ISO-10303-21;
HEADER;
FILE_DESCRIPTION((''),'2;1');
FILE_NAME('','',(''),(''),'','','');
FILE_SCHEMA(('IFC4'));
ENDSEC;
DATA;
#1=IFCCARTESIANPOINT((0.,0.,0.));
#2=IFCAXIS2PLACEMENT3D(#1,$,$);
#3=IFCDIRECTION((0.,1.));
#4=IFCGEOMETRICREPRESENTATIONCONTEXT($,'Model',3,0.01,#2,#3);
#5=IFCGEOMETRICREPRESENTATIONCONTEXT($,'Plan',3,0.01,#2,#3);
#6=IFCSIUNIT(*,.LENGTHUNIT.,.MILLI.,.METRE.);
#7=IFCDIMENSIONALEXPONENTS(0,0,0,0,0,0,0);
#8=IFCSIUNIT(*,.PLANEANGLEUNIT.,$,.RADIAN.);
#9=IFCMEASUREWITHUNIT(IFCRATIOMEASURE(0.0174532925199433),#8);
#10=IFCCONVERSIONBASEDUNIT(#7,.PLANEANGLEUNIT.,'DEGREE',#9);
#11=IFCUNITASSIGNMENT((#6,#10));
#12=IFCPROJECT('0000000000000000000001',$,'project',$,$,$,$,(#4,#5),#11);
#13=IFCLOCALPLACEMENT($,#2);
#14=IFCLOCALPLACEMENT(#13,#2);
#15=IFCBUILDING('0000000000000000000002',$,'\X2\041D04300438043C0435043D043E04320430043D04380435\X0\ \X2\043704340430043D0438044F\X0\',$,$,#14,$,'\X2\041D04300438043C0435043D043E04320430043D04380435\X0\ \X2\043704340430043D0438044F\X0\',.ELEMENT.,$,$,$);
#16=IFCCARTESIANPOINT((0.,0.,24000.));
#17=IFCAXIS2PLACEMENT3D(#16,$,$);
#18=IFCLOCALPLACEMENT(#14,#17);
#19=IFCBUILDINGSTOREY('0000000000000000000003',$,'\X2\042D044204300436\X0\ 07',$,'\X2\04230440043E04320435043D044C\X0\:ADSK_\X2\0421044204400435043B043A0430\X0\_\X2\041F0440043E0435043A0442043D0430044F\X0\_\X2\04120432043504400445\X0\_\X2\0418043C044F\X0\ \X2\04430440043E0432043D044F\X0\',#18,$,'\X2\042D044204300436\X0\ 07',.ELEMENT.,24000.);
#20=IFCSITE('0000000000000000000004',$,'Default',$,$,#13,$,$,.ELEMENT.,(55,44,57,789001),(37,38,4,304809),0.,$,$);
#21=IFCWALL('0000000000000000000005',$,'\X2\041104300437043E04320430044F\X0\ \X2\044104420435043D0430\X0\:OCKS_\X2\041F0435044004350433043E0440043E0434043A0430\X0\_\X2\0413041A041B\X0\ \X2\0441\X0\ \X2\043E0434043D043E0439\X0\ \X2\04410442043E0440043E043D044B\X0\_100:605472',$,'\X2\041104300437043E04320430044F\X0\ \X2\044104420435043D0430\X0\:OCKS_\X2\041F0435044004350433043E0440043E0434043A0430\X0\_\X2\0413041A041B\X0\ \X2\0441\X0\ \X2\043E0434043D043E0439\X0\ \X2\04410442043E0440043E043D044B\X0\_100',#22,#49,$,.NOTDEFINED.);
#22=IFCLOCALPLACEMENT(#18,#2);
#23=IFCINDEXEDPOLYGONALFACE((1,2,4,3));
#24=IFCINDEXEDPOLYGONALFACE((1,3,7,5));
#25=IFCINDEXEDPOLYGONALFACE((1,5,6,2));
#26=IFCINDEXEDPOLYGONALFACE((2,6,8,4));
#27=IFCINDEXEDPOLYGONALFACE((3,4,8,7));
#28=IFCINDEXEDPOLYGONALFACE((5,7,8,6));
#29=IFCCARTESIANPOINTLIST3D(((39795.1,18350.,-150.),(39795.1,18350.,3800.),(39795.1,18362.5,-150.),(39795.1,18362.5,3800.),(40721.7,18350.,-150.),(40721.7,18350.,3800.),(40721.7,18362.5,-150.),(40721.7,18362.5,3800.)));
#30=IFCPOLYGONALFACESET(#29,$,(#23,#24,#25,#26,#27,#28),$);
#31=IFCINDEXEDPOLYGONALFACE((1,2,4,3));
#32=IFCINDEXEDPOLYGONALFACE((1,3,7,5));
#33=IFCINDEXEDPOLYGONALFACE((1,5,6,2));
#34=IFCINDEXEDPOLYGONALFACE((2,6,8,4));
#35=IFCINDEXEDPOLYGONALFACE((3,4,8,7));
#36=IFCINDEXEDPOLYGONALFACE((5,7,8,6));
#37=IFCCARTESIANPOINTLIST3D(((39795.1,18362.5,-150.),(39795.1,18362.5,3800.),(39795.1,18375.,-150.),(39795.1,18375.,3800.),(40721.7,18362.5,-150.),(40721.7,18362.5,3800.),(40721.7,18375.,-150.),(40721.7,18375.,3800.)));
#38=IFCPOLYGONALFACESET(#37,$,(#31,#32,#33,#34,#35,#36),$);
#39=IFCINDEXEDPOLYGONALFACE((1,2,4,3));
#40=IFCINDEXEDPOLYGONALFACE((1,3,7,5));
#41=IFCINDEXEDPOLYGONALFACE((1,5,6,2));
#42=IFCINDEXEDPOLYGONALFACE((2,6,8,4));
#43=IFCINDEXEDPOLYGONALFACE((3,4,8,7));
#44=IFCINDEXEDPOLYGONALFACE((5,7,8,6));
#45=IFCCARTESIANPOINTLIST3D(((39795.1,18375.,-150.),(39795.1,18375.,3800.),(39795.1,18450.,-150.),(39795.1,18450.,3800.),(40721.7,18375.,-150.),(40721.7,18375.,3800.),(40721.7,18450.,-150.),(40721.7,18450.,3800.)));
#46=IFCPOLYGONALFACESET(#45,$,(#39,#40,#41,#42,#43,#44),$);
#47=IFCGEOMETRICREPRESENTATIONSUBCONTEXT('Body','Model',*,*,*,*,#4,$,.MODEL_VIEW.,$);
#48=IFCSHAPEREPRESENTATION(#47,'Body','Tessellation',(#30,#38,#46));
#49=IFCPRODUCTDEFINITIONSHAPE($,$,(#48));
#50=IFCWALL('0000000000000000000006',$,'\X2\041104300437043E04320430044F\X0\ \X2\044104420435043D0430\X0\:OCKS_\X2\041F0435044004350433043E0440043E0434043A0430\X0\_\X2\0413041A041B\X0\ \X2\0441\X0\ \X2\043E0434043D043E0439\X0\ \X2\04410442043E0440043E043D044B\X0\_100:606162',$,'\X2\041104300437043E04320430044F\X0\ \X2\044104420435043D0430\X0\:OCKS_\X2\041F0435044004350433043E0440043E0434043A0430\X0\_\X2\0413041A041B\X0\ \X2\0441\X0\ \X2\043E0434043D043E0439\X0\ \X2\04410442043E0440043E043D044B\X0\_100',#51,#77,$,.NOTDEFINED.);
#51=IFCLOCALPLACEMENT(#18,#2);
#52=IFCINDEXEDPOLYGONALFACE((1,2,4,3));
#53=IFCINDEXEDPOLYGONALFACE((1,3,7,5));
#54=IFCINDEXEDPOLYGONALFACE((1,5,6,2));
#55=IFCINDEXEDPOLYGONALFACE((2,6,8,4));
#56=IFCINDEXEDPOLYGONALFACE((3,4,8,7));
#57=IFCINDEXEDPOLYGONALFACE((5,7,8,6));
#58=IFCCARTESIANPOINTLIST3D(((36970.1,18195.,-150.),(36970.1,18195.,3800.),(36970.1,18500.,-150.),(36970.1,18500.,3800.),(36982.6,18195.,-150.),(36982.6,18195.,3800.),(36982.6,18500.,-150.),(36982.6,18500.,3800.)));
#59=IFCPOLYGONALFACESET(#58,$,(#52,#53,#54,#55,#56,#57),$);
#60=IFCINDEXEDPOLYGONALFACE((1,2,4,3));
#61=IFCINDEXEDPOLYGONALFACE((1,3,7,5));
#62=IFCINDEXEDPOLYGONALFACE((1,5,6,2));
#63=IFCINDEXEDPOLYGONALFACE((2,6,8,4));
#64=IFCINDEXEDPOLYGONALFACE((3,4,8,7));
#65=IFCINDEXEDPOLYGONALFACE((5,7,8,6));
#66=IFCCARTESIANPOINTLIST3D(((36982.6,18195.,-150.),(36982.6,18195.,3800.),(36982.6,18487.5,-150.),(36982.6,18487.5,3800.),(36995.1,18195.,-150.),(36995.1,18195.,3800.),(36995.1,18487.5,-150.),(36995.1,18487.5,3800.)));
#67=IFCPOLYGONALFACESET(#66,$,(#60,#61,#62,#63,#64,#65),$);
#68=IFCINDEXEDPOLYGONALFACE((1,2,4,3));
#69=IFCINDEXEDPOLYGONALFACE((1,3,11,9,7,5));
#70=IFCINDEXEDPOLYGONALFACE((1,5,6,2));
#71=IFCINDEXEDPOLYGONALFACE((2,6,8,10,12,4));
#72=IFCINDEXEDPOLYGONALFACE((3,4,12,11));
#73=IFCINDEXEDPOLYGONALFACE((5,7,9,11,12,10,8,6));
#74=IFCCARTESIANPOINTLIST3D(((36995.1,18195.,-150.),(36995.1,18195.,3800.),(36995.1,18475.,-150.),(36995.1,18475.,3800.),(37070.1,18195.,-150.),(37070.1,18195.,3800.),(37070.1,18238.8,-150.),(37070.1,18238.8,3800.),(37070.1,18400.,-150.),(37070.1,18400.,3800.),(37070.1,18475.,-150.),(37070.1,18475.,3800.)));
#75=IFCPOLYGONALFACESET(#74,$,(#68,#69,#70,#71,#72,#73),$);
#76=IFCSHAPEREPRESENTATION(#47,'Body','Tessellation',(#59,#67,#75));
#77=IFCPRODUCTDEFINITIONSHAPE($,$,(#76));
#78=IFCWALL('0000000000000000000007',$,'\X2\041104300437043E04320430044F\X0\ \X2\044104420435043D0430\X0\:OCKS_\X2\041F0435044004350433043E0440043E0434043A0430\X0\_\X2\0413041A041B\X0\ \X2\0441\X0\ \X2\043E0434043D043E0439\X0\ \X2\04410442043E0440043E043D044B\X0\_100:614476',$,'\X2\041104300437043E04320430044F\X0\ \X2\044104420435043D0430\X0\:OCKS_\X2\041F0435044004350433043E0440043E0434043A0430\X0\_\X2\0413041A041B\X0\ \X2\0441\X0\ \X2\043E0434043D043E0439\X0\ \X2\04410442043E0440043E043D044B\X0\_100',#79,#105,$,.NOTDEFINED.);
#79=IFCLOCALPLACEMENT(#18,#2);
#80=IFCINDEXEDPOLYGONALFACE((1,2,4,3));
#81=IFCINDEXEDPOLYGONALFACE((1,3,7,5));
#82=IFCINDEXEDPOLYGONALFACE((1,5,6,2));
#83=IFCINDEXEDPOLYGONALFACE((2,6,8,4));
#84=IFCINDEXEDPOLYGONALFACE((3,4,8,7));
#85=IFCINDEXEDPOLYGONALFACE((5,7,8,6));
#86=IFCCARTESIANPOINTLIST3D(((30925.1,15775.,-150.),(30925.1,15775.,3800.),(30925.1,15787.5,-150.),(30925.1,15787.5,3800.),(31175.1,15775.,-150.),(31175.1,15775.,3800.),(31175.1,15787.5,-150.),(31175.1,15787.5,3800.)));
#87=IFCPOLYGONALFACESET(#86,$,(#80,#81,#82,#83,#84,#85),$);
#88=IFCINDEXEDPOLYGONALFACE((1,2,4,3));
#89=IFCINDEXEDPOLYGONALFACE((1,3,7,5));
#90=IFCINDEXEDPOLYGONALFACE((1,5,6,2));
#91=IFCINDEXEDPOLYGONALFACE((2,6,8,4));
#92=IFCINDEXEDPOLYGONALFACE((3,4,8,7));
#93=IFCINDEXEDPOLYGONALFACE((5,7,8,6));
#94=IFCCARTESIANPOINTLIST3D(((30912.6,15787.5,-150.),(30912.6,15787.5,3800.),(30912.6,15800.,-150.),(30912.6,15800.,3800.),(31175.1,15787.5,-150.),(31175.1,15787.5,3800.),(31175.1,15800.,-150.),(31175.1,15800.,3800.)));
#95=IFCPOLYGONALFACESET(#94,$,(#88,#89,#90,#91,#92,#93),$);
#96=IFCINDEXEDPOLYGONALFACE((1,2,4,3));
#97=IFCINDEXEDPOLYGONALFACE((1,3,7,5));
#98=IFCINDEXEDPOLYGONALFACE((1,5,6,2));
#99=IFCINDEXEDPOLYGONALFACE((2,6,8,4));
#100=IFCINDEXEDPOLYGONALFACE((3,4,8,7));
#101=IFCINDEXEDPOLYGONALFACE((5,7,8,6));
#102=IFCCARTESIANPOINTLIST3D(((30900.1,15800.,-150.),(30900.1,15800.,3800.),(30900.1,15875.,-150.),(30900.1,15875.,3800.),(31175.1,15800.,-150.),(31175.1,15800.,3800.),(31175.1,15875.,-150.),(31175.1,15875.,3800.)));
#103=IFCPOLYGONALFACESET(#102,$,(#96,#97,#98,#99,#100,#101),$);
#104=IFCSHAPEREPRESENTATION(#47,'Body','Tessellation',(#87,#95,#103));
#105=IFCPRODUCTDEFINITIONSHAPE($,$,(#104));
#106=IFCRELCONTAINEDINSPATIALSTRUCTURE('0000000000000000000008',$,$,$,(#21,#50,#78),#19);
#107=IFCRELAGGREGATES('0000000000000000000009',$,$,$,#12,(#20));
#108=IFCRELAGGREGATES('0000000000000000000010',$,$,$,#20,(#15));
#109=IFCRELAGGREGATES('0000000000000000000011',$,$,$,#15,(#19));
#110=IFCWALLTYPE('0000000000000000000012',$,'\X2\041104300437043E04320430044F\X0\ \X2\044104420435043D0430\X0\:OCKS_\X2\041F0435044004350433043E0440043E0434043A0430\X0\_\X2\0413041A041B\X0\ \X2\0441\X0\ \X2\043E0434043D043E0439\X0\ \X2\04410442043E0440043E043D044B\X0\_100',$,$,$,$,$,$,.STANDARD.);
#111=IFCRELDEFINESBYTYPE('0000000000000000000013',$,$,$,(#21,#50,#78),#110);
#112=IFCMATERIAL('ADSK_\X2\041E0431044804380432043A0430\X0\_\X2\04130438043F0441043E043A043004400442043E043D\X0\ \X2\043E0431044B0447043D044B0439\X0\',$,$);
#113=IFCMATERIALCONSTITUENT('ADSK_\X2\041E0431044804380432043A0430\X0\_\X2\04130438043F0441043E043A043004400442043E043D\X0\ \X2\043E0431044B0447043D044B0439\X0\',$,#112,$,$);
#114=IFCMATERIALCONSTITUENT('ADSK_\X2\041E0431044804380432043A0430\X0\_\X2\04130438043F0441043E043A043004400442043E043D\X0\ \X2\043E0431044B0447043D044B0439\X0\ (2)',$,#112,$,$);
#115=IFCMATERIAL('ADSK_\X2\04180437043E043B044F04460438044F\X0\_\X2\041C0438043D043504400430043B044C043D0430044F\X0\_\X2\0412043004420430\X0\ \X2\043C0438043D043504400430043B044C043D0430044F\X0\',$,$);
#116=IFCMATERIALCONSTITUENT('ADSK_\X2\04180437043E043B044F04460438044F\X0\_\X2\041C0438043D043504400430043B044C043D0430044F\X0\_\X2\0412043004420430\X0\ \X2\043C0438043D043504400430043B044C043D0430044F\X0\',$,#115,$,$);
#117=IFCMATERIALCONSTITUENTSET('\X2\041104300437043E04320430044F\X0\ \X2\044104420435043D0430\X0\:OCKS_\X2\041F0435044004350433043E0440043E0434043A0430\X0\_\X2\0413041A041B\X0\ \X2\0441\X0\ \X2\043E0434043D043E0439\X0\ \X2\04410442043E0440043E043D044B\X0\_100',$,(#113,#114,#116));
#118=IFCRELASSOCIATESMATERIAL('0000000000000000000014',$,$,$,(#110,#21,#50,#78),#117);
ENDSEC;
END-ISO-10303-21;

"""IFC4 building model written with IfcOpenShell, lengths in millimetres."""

from ifc_helpers import new_model, entity, si_unit, converted_unit, direction, frame, origin, place, context, subcontext, project, spatial, indexed_curve, outline, extrude, material, constituent, constituent_set, type_object, element, save


model = new_model("IFC4")

# Units and contexts
model_context = context("Model", 3, precision=0.01, world=origin(), true_north=direction((0.0, 1.0)))
plan_context = context("Plan", 3, precision=0.01, world=origin(), true_north=direction((0.0, 1.0)))
body_context = subcontext(model_context, "Body", "Model", "MODEL_VIEW")
ifc_project = project(units=[si_unit("LENGTHUNIT", "METRE", prefix="MILLI"), converted_unit("PLANEANGLEUNIT", "DEGREE", entity("IfcRatioMeasure", 0.0174532925199433), si_unit("PLANEANGLEUNIT", "RADIAN"), dimensions=[0, 0, 0, 0, 0, 0, 0])], contexts=[model_context, plan_context])

# Site, building, storey
site_placement = place(None, frame((0.0, 0.0, 0.0)))
site = spatial("IfcSite", under=ifc_project, at=site_placement, Name="Default", CompositionType="ELEMENT", RefLatitude=(55, 44, 57, 789001), RefLongitude=(37, 38, 4, 304809), RefElevation=0.0)
building_placement = place(site_placement, origin())
building = spatial("IfcBuilding", under=site, at=building_placement, Name="Наименование здания", LongName="Наименование здания", CompositionType="ELEMENT")
storey_placement = place(building_placement, frame((0.0, 0.0, 24000.0)))
storey = spatial("IfcBuildingStorey", under=building, at=storey_placement, Name="Этаж 07", ObjectType="Уровень:ADSK_Стрелка_Проектная_Вверх_Имя уровня", LongName="Этаж 07", CompositionType="ELEMENT", Elevation=24000.0)

# Shared definitions
ifc_material_1 = material(Name="ADSK_Обшивка_Гипсокартон обычный")
ifc_material_2 = material(Name="ADSK_Изоляция_Минеральная_Вата минеральная")

# Walls
ifc_constituent_1 = constituent(ifc_material_1, Name="ADSK_Обшивка_Гипсокартон обычный")
ifc_constituent_2 = constituent(ifc_material_1, Name="ADSK_Обшивка_Гипсокартон обычный (2)")
ifc_constituent_3 = constituent(ifc_material_2, Name="ADSK_Изоляция_Минеральная_Вата минеральная")
ifc_constituent_set_1 = constituent_set(constituents=[ifc_constituent_1, ifc_constituent_2, ifc_constituent_3], Name="Базовая стена:OCKS_Перегородка_ГКЛ с одной стороны_100")
wall_type_1 = type_object("IfcWallType", Name="Базовая стена:OCKS_Перегородка_ГКЛ с одной стороны_100", PredefinedType="STANDARD", material=ifc_constituent_set_1)
wall_1_placement = place(storey_placement, frame((40721.7, 18400.0, -150.0), z_axis=(0.0, 0.0, 1.0), x_axis=(-1.0, 0.0, 0.0)))
element("IfcWall", 1, at=wall_1_placement, inside=storey, type_object=wall_type_1, material=ifc_constituent_set_1, Name="Базовая стена:OCKS_Перегородка_ГКЛ с одной стороны_100:605472", ObjectType="Базовая стена:OCKS_Перегородка_ГКЛ с одной стороны_100", PredefinedType="NOTDEFINED", context=body_context, shape_type="SweptSolid", body=[
    extrude(outline(indexed_curve([(-6.3, -463.3), (6.2, -463.3), (6.3, 463.3), (-6.2, 463.3), (-6.3, -463.3)], self_intersect=False)), frame((463.3, 43.7, 0.0), z_axis=(0.0, 0.0, 1.0), x_axis=(0.0, -1.0, 0.0)), (0.0, 0.0, 1.0), 3950.0),
    extrude(outline(indexed_curve([(-463.3, -6.2), (463.3, -6.2), (463.3, 6.3), (-463.3, 6.3), (-463.3, -6.2)], self_intersect=False)), frame((463.3, 31.2, 0.0)), (0.0, 0.0, 1.0), 3950.0),
    extrude(outline(indexed_curve([(-37.5, -463.3), (37.5, -463.3), (37.5, 463.3), (-37.5, 463.3), (-37.5, -463.3)], self_intersect=False)), frame((463.3, -12.5, 0.0), z_axis=(0.0, 0.0, 1.0), x_axis=(0.0, 1.0, 0.0)), (0.0, 0.0, 1.0), 3950.0),
])
wall_2_placement = place(storey_placement, frame((37020.1, 18195.0, -150.0), z_axis=(0.0, 0.0, 1.0), x_axis=(0.0, 1.0, 0.0)))
element("IfcWall", 2, at=wall_2_placement, inside=storey, type_object=wall_type_1, material=ifc_constituent_set_1, Name="Базовая стена:OCKS_Перегородка_ГКЛ с одной стороны_100:606162", ObjectType="Базовая стена:OCKS_Перегородка_ГКЛ с одной стороны_100", PredefinedType="NOTDEFINED", context=body_context, shape_type="SweptSolid", body=[
    extrude(outline(indexed_curve([(-6.3, -152.5), (6.2, -152.5), (6.2, 152.5), (-6.3, 152.5), (-6.3, -152.5)], self_intersect=False)), frame((152.5, 43.7, 0.0), z_axis=(0.0, 0.0, 1.0), x_axis=(0.0, -1.0, 0.0)), (0.0, 0.0, 1.0), 3950.0),
    extrude(outline(indexed_curve([(-146.2, -6.3), (146.2, -6.3), (146.2, 6.2), (-146.2, 6.2), (-146.2, -6.3)], self_intersect=False)), frame((146.2, 31.3, 0.0)), (0.0, 0.0, 1.0), 3950.0),
    extrude(outline(indexed_curve([(-91.0, -25.0), (70.2, -25.0), (145.2, -25.0), (145.2, 50.0), (-134.8, 50.0), (-134.8, -25.0), (-91.0, -25.0)], self_intersect=False)), frame((134.8, -25.0, 0.0)), (0.0, 0.0, 1.0), 3950.0),
])
wall_3_placement = place(storey_placement, frame((30925.1, 15825.0, -150.0)))
element("IfcWall", 3, at=wall_3_placement, inside=storey, type_object=wall_type_1, material=ifc_constituent_set_1, Name="Базовая стена:OCKS_Перегородка_ГКЛ с одной стороны_100:614476", ObjectType="Базовая стена:OCKS_Перегородка_ГКЛ с одной стороны_100", PredefinedType="NOTDEFINED", context=body_context, shape_type="SweptSolid", body=[
    extrude(outline(indexed_curve([(-6.3, -125.0), (6.2, -125.0), (6.3, 125.0), (-6.3, 125.0), (-6.3, -125.0)], self_intersect=False)), frame((125.0, -43.8, 0.0), z_axis=(0.0, 0.0, 1.0), x_axis=(0.0, 1.0, 0.0)), (0.0, 0.0, 1.0), 3950.0),
    extrude(outline(indexed_curve([(-131.2, -6.2), (131.2, -6.2), (131.2, 6.2), (-131.2, 6.2), (-131.2, -6.2)], self_intersect=False)), frame((118.7, -31.3, 0.0)), (0.0, 0.0, 1.0), 3950.0),
    extrude(outline(indexed_curve([(-37.5, -137.5), (37.5, -137.5), (37.5, 137.5), (-37.5, 137.5), (-37.5, -137.5)], self_intersect=False)), frame((112.5, 12.5, 0.0), z_axis=(0.0, 0.0, 1.0), x_axis=(0.0, -1.0, 0.0)), (0.0, 0.0, 1.0), 3950.0),
])

save(model, "model.ifc")
